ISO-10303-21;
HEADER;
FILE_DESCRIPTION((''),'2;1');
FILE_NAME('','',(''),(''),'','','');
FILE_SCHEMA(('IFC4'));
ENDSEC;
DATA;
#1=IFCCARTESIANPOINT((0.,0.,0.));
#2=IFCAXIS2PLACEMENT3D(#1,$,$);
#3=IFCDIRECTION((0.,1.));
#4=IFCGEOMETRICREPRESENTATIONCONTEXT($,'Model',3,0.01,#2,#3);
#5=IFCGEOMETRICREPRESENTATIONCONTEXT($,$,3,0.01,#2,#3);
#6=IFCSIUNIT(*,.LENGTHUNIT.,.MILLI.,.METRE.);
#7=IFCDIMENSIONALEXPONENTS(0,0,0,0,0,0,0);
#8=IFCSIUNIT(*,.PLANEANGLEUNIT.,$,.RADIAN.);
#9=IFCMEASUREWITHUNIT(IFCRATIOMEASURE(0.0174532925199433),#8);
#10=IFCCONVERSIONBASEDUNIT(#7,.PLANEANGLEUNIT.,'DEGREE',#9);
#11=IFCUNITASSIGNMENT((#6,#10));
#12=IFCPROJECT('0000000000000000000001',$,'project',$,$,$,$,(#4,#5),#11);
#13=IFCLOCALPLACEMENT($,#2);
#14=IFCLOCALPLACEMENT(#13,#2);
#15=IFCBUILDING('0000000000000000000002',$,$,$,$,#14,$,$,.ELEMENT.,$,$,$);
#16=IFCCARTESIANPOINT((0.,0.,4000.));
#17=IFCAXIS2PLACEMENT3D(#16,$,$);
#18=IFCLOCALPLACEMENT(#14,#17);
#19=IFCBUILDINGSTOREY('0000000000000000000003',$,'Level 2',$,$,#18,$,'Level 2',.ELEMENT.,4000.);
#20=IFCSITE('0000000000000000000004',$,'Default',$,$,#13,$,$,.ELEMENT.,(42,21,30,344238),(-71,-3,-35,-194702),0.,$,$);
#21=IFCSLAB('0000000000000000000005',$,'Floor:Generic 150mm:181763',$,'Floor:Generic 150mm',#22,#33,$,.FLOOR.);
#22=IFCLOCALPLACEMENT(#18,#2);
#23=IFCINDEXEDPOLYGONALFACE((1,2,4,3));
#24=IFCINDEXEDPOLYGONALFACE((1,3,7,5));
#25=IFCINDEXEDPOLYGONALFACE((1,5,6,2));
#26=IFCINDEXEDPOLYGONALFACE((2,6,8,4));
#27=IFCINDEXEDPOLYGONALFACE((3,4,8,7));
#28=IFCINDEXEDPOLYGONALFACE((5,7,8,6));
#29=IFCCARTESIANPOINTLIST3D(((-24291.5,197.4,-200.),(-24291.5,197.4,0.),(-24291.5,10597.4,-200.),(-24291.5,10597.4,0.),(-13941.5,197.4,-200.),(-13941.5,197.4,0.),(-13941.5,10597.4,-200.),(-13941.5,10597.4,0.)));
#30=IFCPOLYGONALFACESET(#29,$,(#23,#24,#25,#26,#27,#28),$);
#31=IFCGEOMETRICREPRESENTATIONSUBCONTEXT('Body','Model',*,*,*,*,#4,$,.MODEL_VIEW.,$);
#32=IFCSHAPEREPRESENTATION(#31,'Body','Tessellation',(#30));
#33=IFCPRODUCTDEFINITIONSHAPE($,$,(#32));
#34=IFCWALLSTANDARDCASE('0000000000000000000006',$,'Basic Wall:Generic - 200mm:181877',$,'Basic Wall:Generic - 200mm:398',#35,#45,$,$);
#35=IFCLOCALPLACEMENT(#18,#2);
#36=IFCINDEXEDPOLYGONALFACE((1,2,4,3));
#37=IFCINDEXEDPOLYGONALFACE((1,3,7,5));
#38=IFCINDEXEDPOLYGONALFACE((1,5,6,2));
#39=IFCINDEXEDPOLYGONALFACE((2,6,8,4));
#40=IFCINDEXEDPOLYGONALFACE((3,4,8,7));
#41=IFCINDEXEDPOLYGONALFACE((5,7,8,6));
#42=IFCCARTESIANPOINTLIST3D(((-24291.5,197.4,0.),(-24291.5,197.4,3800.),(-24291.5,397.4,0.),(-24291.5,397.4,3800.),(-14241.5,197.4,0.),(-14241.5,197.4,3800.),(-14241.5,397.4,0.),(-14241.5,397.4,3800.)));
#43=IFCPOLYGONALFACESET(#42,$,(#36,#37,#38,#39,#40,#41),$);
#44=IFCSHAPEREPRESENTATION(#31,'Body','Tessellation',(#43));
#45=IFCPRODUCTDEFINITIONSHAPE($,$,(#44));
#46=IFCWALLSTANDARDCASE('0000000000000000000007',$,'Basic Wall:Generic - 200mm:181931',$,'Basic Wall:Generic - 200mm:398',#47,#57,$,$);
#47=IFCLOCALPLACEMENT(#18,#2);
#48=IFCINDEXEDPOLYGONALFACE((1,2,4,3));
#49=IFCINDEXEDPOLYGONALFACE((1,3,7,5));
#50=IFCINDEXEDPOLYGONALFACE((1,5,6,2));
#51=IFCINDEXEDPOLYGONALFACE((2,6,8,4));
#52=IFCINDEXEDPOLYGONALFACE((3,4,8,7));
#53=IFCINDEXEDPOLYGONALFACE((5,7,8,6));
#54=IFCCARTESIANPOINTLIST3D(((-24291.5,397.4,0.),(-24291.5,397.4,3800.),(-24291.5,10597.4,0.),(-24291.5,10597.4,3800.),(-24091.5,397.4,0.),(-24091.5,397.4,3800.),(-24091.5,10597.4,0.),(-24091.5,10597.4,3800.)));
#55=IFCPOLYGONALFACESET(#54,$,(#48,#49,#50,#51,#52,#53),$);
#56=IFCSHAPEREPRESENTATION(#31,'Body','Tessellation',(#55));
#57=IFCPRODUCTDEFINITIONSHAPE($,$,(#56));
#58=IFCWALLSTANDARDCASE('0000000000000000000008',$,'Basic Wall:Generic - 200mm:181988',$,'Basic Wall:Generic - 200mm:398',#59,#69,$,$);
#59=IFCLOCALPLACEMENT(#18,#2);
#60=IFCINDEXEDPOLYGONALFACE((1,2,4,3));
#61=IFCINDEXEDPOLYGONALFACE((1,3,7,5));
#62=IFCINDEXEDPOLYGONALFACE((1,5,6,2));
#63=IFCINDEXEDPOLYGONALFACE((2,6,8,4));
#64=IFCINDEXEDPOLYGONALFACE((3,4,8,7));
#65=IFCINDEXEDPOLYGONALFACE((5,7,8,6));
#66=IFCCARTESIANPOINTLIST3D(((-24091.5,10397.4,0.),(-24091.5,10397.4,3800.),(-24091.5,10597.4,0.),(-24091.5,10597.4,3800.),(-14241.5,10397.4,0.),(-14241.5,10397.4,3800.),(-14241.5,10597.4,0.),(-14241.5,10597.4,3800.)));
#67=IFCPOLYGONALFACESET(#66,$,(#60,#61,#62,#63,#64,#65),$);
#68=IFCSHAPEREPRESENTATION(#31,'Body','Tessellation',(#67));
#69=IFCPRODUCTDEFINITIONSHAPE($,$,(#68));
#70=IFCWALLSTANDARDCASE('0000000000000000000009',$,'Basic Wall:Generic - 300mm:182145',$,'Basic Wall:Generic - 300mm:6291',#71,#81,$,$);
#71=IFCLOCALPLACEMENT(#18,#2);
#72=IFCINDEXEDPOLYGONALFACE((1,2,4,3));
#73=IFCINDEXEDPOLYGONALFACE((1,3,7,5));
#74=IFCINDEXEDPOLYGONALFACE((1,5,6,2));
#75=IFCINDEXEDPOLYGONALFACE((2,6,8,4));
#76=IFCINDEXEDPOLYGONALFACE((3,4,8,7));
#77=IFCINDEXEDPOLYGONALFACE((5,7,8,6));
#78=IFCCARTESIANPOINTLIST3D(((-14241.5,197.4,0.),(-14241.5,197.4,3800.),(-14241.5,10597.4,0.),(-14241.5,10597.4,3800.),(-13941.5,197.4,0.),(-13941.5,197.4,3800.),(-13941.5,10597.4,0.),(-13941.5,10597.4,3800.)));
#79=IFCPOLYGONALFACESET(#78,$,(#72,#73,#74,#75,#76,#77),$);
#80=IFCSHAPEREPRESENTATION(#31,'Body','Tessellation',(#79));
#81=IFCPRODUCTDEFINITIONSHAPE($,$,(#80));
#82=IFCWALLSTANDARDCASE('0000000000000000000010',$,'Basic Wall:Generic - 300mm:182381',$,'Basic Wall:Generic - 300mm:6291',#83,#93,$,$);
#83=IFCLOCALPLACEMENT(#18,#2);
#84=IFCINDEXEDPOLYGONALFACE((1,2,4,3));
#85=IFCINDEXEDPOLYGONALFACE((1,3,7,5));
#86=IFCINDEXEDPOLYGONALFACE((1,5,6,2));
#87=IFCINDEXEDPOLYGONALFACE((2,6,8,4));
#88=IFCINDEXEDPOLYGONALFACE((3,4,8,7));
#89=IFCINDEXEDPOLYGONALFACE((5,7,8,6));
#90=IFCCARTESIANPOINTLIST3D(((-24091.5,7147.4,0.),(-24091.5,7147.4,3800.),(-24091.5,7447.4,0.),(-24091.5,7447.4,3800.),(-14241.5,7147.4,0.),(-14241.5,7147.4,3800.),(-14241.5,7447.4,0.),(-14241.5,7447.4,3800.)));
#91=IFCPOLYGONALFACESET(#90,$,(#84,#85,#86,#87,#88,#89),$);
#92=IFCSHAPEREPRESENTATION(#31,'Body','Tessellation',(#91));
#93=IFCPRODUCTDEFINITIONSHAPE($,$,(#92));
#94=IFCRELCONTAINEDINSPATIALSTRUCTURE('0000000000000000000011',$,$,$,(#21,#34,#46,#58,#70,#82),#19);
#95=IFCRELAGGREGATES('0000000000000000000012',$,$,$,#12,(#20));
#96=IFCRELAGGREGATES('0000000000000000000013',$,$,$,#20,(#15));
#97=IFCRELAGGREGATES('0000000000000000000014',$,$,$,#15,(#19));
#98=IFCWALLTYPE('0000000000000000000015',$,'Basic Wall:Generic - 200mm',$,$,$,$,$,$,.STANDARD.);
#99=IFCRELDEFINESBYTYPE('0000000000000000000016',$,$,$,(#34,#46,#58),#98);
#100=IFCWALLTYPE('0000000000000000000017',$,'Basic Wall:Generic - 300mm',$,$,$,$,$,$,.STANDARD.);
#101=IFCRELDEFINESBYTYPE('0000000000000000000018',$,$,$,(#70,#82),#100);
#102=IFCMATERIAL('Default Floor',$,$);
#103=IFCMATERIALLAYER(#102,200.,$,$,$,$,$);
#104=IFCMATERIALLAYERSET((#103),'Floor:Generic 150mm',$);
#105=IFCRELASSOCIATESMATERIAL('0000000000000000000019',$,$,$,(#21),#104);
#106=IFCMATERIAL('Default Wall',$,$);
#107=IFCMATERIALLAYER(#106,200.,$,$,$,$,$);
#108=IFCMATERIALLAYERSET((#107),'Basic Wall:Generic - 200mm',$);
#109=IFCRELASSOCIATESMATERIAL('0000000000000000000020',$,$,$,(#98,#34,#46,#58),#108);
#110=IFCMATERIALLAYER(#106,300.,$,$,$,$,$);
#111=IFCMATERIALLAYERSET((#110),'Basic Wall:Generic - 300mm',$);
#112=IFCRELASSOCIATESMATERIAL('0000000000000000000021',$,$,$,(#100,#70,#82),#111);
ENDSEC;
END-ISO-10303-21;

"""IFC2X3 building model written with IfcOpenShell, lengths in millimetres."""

from ifc_helpers import new_model, entity, si_unit, converted_unit, direction, frame, frame_2d, origin, place, context, subcontext, project, spatial, rectangle, extrude, material, layer, layer_set, layer_usage, type_object, element, save


model = new_model("IFC2X3")

# Units and contexts
model_context = context("Model", 3, precision=0.01, world=origin(), true_north=direction((0.0, 1.0)))
context_of_model = context(None, 3, precision=0.01, world=origin(), true_north=direction((0.0, 1.0)))
body_context = subcontext(model_context, "Body", "Model", "MODEL_VIEW")
ifc_project = project(units=[si_unit("LENGTHUNIT", "METRE", prefix="MILLI"), converted_unit("PLANEANGLEUNIT", "DEGREE", entity("IfcRatioMeasure", 0.0174532925199433), si_unit("PLANEANGLEUNIT", "RADIAN"), dimensions=[0, 0, 0, 0, 0, 0, 0])], contexts=[model_context, context_of_model])

# Site, building, storey
site_placement = place(None, origin())
site = spatial("IfcSite", under=ifc_project, at=site_placement, Name="Default", CompositionType="ELEMENT", RefLatitude=(42, 21, 30, 344238), RefLongitude=(-71, -3, -35, -194702), RefElevation=0.0)
building_placement = place(site_placement, origin())
building = spatial("IfcBuilding", under=site, at=building_placement, CompositionType="ELEMENT")
storey_placement = place(building_placement, frame((0.0, 0.0, 4000.0)))
storey = spatial("IfcBuildingStorey", under=building, at=storey_placement, Name="Level 2", LongName="Level 2", CompositionType="ELEMENT", Elevation=4000.0)

# Slab
ifc_material_1 = material(Name="Default Floor")
ifc_layer_1 = layer(ifc_material_1, 200.0)
ifc_layer_set_1 = layer_set([ifc_layer_1], Name="Floor:Generic 150mm")
ifc_layer_usage_1 = layer_usage(ifc_layer_set_1, "AXIS3", "POSITIVE", 0.0)
slab_placement = place(storey_placement, origin())
element("IfcSlab", 1, at=slab_placement, inside=storey, material=ifc_layer_usage_1, Name="Floor:Generic 150mm:181763", ObjectType="Floor:Generic 150mm", PredefinedType="FLOOR", context=body_context, shape_type="SweptSolid", body=[
    extrude(rectangle(XDim=10400.0, YDim=10350.0, at=frame_2d((0.0, 0.0), x_axis=(1.0, 0.0))), frame((-19116.5, 5397.4, 0.0), z_axis=(0.0, 0.0, -1.0), x_axis=(0.0, 1.0, 0.0)), (0.0, 0.0, 1.0), 200.0),
])

# Walls
ifc_material_2 = material(Name="Default Wall")
ifc_layer_2 = layer(ifc_material_2, 200.0)
ifc_layer_set_2 = layer_set([ifc_layer_2], Name="Basic Wall:Generic - 200mm")
ifc_layer_usage_2 = layer_usage(ifc_layer_set_2, "AXIS2", "NEGATIVE", 100.0)
wall_type_1 = type_object("IfcWallType", Name="Basic Wall:Generic - 200mm", PredefinedType="STANDARD", material=ifc_layer_set_2)
wall_1_placement = place(storey_placement, frame((-14241.5, 297.4, 0.0), z_axis=(0.0, 0.0, 1.0), x_axis=(-1.0, 0.0, 0.0)))
element("IfcWallStandardCase", 2, at=wall_1_placement, inside=storey, type_object=wall_type_1, material=ifc_layer_usage_2, Name="Basic Wall:Generic - 200mm:181877", ObjectType="Basic Wall:Generic - 200mm:398", context=body_context, shape_type="SweptSolid", body=[
    extrude(rectangle(XDim=10050.0, YDim=200.0, at=frame_2d((5025.0, 0.0), x_axis=(-1.0, 0.0))), origin(), (0.0, 0.0, 1.0), 3800.0),
])
ifc_layer_usage_3 = layer_usage(ifc_layer_set_2, "AXIS2", "NEGATIVE", 100.0)
wall_2_placement = place(storey_placement, frame((-24191.5, 397.4, 0.0), z_axis=(0.0, 0.0, 1.0), x_axis=(0.0, 1.0, 0.0)))
element("IfcWallStandardCase", 3, at=wall_2_placement, inside=storey, type_object=wall_type_1, material=ifc_layer_usage_3, Name="Basic Wall:Generic - 200mm:181931", ObjectType="Basic Wall:Generic - 200mm:398", context=body_context, shape_type="SweptSolid", body=[
    extrude(rectangle(XDim=10200.0, YDim=200.0, at=frame_2d((5100.0, 0.0), x_axis=(-1.0, 0.0))), origin(), (0.0, 0.0, 1.0), 3800.0),
])
ifc_layer_usage_4 = layer_usage(ifc_layer_set_2, "AXIS2", "NEGATIVE", 100.0)
wall_3_placement = place(storey_placement, frame((-24091.5, 10497.4, 0.0)))
element("IfcWallStandardCase", 4, at=wall_3_placement, inside=storey, type_object=wall_type_1, material=ifc_layer_usage_4, Name="Basic Wall:Generic - 200mm:181988", ObjectType="Basic Wall:Generic - 200mm:398", context=body_context, shape_type="SweptSolid", body=[
    extrude(rectangle(XDim=9850.0, YDim=200.0, at=frame_2d((4925.0, 0.0), x_axis=(-1.0, 0.0))), origin(), (0.0, 0.0, 1.0), 3800.0),
])
ifc_layer_3 = layer(ifc_material_2, 300.0)
ifc_layer_set_3 = layer_set([ifc_layer_3], Name="Basic Wall:Generic - 300mm")
ifc_layer_usage_5 = layer_usage(ifc_layer_set_3, "AXIS2", "NEGATIVE", 150.0)
wall_type_2 = type_object("IfcWallType", Name="Basic Wall:Generic - 300mm", PredefinedType="STANDARD", material=ifc_layer_set_3)
wall_4_placement = place(storey_placement, frame((-14091.5, 10597.4, 0.0), z_axis=(0.0, 0.0, 1.0), x_axis=(0.0, -1.0, 0.0)))
element("IfcWallStandardCase", 5, at=wall_4_placement, inside=storey, type_object=wall_type_2, material=ifc_layer_usage_5, Name="Basic Wall:Generic - 300mm:182145", ObjectType="Basic Wall:Generic - 300mm:6291", context=body_context, shape_type="SweptSolid", body=[
    extrude(rectangle(XDim=10400.0, YDim=300.0, at=frame_2d((5200.0, 0.0), x_axis=(-1.0, 0.0))), origin(), (0.0, 0.0, 1.0), 3800.0),
])
ifc_layer_usage_6 = layer_usage(ifc_layer_set_3, "AXIS2", "NEGATIVE", 150.0)
wall_5_placement = place(storey_placement, frame((-24091.5, 7297.4, 0.0)))
element("IfcWallStandardCase", 6, at=wall_5_placement, inside=storey, type_object=wall_type_2, material=ifc_layer_usage_6, Name="Basic Wall:Generic - 300mm:182381", ObjectType="Basic Wall:Generic - 300mm:6291", context=body_context, shape_type="SweptSolid", body=[
    extrude(rectangle(XDim=9850.0, YDim=300.0, at=frame_2d((4925.0, 0.0), x_axis=(-1.0, 0.0))), origin(), (0.0, 0.0, 1.0), 3800.0),
])

save(model, "model.ifc")
